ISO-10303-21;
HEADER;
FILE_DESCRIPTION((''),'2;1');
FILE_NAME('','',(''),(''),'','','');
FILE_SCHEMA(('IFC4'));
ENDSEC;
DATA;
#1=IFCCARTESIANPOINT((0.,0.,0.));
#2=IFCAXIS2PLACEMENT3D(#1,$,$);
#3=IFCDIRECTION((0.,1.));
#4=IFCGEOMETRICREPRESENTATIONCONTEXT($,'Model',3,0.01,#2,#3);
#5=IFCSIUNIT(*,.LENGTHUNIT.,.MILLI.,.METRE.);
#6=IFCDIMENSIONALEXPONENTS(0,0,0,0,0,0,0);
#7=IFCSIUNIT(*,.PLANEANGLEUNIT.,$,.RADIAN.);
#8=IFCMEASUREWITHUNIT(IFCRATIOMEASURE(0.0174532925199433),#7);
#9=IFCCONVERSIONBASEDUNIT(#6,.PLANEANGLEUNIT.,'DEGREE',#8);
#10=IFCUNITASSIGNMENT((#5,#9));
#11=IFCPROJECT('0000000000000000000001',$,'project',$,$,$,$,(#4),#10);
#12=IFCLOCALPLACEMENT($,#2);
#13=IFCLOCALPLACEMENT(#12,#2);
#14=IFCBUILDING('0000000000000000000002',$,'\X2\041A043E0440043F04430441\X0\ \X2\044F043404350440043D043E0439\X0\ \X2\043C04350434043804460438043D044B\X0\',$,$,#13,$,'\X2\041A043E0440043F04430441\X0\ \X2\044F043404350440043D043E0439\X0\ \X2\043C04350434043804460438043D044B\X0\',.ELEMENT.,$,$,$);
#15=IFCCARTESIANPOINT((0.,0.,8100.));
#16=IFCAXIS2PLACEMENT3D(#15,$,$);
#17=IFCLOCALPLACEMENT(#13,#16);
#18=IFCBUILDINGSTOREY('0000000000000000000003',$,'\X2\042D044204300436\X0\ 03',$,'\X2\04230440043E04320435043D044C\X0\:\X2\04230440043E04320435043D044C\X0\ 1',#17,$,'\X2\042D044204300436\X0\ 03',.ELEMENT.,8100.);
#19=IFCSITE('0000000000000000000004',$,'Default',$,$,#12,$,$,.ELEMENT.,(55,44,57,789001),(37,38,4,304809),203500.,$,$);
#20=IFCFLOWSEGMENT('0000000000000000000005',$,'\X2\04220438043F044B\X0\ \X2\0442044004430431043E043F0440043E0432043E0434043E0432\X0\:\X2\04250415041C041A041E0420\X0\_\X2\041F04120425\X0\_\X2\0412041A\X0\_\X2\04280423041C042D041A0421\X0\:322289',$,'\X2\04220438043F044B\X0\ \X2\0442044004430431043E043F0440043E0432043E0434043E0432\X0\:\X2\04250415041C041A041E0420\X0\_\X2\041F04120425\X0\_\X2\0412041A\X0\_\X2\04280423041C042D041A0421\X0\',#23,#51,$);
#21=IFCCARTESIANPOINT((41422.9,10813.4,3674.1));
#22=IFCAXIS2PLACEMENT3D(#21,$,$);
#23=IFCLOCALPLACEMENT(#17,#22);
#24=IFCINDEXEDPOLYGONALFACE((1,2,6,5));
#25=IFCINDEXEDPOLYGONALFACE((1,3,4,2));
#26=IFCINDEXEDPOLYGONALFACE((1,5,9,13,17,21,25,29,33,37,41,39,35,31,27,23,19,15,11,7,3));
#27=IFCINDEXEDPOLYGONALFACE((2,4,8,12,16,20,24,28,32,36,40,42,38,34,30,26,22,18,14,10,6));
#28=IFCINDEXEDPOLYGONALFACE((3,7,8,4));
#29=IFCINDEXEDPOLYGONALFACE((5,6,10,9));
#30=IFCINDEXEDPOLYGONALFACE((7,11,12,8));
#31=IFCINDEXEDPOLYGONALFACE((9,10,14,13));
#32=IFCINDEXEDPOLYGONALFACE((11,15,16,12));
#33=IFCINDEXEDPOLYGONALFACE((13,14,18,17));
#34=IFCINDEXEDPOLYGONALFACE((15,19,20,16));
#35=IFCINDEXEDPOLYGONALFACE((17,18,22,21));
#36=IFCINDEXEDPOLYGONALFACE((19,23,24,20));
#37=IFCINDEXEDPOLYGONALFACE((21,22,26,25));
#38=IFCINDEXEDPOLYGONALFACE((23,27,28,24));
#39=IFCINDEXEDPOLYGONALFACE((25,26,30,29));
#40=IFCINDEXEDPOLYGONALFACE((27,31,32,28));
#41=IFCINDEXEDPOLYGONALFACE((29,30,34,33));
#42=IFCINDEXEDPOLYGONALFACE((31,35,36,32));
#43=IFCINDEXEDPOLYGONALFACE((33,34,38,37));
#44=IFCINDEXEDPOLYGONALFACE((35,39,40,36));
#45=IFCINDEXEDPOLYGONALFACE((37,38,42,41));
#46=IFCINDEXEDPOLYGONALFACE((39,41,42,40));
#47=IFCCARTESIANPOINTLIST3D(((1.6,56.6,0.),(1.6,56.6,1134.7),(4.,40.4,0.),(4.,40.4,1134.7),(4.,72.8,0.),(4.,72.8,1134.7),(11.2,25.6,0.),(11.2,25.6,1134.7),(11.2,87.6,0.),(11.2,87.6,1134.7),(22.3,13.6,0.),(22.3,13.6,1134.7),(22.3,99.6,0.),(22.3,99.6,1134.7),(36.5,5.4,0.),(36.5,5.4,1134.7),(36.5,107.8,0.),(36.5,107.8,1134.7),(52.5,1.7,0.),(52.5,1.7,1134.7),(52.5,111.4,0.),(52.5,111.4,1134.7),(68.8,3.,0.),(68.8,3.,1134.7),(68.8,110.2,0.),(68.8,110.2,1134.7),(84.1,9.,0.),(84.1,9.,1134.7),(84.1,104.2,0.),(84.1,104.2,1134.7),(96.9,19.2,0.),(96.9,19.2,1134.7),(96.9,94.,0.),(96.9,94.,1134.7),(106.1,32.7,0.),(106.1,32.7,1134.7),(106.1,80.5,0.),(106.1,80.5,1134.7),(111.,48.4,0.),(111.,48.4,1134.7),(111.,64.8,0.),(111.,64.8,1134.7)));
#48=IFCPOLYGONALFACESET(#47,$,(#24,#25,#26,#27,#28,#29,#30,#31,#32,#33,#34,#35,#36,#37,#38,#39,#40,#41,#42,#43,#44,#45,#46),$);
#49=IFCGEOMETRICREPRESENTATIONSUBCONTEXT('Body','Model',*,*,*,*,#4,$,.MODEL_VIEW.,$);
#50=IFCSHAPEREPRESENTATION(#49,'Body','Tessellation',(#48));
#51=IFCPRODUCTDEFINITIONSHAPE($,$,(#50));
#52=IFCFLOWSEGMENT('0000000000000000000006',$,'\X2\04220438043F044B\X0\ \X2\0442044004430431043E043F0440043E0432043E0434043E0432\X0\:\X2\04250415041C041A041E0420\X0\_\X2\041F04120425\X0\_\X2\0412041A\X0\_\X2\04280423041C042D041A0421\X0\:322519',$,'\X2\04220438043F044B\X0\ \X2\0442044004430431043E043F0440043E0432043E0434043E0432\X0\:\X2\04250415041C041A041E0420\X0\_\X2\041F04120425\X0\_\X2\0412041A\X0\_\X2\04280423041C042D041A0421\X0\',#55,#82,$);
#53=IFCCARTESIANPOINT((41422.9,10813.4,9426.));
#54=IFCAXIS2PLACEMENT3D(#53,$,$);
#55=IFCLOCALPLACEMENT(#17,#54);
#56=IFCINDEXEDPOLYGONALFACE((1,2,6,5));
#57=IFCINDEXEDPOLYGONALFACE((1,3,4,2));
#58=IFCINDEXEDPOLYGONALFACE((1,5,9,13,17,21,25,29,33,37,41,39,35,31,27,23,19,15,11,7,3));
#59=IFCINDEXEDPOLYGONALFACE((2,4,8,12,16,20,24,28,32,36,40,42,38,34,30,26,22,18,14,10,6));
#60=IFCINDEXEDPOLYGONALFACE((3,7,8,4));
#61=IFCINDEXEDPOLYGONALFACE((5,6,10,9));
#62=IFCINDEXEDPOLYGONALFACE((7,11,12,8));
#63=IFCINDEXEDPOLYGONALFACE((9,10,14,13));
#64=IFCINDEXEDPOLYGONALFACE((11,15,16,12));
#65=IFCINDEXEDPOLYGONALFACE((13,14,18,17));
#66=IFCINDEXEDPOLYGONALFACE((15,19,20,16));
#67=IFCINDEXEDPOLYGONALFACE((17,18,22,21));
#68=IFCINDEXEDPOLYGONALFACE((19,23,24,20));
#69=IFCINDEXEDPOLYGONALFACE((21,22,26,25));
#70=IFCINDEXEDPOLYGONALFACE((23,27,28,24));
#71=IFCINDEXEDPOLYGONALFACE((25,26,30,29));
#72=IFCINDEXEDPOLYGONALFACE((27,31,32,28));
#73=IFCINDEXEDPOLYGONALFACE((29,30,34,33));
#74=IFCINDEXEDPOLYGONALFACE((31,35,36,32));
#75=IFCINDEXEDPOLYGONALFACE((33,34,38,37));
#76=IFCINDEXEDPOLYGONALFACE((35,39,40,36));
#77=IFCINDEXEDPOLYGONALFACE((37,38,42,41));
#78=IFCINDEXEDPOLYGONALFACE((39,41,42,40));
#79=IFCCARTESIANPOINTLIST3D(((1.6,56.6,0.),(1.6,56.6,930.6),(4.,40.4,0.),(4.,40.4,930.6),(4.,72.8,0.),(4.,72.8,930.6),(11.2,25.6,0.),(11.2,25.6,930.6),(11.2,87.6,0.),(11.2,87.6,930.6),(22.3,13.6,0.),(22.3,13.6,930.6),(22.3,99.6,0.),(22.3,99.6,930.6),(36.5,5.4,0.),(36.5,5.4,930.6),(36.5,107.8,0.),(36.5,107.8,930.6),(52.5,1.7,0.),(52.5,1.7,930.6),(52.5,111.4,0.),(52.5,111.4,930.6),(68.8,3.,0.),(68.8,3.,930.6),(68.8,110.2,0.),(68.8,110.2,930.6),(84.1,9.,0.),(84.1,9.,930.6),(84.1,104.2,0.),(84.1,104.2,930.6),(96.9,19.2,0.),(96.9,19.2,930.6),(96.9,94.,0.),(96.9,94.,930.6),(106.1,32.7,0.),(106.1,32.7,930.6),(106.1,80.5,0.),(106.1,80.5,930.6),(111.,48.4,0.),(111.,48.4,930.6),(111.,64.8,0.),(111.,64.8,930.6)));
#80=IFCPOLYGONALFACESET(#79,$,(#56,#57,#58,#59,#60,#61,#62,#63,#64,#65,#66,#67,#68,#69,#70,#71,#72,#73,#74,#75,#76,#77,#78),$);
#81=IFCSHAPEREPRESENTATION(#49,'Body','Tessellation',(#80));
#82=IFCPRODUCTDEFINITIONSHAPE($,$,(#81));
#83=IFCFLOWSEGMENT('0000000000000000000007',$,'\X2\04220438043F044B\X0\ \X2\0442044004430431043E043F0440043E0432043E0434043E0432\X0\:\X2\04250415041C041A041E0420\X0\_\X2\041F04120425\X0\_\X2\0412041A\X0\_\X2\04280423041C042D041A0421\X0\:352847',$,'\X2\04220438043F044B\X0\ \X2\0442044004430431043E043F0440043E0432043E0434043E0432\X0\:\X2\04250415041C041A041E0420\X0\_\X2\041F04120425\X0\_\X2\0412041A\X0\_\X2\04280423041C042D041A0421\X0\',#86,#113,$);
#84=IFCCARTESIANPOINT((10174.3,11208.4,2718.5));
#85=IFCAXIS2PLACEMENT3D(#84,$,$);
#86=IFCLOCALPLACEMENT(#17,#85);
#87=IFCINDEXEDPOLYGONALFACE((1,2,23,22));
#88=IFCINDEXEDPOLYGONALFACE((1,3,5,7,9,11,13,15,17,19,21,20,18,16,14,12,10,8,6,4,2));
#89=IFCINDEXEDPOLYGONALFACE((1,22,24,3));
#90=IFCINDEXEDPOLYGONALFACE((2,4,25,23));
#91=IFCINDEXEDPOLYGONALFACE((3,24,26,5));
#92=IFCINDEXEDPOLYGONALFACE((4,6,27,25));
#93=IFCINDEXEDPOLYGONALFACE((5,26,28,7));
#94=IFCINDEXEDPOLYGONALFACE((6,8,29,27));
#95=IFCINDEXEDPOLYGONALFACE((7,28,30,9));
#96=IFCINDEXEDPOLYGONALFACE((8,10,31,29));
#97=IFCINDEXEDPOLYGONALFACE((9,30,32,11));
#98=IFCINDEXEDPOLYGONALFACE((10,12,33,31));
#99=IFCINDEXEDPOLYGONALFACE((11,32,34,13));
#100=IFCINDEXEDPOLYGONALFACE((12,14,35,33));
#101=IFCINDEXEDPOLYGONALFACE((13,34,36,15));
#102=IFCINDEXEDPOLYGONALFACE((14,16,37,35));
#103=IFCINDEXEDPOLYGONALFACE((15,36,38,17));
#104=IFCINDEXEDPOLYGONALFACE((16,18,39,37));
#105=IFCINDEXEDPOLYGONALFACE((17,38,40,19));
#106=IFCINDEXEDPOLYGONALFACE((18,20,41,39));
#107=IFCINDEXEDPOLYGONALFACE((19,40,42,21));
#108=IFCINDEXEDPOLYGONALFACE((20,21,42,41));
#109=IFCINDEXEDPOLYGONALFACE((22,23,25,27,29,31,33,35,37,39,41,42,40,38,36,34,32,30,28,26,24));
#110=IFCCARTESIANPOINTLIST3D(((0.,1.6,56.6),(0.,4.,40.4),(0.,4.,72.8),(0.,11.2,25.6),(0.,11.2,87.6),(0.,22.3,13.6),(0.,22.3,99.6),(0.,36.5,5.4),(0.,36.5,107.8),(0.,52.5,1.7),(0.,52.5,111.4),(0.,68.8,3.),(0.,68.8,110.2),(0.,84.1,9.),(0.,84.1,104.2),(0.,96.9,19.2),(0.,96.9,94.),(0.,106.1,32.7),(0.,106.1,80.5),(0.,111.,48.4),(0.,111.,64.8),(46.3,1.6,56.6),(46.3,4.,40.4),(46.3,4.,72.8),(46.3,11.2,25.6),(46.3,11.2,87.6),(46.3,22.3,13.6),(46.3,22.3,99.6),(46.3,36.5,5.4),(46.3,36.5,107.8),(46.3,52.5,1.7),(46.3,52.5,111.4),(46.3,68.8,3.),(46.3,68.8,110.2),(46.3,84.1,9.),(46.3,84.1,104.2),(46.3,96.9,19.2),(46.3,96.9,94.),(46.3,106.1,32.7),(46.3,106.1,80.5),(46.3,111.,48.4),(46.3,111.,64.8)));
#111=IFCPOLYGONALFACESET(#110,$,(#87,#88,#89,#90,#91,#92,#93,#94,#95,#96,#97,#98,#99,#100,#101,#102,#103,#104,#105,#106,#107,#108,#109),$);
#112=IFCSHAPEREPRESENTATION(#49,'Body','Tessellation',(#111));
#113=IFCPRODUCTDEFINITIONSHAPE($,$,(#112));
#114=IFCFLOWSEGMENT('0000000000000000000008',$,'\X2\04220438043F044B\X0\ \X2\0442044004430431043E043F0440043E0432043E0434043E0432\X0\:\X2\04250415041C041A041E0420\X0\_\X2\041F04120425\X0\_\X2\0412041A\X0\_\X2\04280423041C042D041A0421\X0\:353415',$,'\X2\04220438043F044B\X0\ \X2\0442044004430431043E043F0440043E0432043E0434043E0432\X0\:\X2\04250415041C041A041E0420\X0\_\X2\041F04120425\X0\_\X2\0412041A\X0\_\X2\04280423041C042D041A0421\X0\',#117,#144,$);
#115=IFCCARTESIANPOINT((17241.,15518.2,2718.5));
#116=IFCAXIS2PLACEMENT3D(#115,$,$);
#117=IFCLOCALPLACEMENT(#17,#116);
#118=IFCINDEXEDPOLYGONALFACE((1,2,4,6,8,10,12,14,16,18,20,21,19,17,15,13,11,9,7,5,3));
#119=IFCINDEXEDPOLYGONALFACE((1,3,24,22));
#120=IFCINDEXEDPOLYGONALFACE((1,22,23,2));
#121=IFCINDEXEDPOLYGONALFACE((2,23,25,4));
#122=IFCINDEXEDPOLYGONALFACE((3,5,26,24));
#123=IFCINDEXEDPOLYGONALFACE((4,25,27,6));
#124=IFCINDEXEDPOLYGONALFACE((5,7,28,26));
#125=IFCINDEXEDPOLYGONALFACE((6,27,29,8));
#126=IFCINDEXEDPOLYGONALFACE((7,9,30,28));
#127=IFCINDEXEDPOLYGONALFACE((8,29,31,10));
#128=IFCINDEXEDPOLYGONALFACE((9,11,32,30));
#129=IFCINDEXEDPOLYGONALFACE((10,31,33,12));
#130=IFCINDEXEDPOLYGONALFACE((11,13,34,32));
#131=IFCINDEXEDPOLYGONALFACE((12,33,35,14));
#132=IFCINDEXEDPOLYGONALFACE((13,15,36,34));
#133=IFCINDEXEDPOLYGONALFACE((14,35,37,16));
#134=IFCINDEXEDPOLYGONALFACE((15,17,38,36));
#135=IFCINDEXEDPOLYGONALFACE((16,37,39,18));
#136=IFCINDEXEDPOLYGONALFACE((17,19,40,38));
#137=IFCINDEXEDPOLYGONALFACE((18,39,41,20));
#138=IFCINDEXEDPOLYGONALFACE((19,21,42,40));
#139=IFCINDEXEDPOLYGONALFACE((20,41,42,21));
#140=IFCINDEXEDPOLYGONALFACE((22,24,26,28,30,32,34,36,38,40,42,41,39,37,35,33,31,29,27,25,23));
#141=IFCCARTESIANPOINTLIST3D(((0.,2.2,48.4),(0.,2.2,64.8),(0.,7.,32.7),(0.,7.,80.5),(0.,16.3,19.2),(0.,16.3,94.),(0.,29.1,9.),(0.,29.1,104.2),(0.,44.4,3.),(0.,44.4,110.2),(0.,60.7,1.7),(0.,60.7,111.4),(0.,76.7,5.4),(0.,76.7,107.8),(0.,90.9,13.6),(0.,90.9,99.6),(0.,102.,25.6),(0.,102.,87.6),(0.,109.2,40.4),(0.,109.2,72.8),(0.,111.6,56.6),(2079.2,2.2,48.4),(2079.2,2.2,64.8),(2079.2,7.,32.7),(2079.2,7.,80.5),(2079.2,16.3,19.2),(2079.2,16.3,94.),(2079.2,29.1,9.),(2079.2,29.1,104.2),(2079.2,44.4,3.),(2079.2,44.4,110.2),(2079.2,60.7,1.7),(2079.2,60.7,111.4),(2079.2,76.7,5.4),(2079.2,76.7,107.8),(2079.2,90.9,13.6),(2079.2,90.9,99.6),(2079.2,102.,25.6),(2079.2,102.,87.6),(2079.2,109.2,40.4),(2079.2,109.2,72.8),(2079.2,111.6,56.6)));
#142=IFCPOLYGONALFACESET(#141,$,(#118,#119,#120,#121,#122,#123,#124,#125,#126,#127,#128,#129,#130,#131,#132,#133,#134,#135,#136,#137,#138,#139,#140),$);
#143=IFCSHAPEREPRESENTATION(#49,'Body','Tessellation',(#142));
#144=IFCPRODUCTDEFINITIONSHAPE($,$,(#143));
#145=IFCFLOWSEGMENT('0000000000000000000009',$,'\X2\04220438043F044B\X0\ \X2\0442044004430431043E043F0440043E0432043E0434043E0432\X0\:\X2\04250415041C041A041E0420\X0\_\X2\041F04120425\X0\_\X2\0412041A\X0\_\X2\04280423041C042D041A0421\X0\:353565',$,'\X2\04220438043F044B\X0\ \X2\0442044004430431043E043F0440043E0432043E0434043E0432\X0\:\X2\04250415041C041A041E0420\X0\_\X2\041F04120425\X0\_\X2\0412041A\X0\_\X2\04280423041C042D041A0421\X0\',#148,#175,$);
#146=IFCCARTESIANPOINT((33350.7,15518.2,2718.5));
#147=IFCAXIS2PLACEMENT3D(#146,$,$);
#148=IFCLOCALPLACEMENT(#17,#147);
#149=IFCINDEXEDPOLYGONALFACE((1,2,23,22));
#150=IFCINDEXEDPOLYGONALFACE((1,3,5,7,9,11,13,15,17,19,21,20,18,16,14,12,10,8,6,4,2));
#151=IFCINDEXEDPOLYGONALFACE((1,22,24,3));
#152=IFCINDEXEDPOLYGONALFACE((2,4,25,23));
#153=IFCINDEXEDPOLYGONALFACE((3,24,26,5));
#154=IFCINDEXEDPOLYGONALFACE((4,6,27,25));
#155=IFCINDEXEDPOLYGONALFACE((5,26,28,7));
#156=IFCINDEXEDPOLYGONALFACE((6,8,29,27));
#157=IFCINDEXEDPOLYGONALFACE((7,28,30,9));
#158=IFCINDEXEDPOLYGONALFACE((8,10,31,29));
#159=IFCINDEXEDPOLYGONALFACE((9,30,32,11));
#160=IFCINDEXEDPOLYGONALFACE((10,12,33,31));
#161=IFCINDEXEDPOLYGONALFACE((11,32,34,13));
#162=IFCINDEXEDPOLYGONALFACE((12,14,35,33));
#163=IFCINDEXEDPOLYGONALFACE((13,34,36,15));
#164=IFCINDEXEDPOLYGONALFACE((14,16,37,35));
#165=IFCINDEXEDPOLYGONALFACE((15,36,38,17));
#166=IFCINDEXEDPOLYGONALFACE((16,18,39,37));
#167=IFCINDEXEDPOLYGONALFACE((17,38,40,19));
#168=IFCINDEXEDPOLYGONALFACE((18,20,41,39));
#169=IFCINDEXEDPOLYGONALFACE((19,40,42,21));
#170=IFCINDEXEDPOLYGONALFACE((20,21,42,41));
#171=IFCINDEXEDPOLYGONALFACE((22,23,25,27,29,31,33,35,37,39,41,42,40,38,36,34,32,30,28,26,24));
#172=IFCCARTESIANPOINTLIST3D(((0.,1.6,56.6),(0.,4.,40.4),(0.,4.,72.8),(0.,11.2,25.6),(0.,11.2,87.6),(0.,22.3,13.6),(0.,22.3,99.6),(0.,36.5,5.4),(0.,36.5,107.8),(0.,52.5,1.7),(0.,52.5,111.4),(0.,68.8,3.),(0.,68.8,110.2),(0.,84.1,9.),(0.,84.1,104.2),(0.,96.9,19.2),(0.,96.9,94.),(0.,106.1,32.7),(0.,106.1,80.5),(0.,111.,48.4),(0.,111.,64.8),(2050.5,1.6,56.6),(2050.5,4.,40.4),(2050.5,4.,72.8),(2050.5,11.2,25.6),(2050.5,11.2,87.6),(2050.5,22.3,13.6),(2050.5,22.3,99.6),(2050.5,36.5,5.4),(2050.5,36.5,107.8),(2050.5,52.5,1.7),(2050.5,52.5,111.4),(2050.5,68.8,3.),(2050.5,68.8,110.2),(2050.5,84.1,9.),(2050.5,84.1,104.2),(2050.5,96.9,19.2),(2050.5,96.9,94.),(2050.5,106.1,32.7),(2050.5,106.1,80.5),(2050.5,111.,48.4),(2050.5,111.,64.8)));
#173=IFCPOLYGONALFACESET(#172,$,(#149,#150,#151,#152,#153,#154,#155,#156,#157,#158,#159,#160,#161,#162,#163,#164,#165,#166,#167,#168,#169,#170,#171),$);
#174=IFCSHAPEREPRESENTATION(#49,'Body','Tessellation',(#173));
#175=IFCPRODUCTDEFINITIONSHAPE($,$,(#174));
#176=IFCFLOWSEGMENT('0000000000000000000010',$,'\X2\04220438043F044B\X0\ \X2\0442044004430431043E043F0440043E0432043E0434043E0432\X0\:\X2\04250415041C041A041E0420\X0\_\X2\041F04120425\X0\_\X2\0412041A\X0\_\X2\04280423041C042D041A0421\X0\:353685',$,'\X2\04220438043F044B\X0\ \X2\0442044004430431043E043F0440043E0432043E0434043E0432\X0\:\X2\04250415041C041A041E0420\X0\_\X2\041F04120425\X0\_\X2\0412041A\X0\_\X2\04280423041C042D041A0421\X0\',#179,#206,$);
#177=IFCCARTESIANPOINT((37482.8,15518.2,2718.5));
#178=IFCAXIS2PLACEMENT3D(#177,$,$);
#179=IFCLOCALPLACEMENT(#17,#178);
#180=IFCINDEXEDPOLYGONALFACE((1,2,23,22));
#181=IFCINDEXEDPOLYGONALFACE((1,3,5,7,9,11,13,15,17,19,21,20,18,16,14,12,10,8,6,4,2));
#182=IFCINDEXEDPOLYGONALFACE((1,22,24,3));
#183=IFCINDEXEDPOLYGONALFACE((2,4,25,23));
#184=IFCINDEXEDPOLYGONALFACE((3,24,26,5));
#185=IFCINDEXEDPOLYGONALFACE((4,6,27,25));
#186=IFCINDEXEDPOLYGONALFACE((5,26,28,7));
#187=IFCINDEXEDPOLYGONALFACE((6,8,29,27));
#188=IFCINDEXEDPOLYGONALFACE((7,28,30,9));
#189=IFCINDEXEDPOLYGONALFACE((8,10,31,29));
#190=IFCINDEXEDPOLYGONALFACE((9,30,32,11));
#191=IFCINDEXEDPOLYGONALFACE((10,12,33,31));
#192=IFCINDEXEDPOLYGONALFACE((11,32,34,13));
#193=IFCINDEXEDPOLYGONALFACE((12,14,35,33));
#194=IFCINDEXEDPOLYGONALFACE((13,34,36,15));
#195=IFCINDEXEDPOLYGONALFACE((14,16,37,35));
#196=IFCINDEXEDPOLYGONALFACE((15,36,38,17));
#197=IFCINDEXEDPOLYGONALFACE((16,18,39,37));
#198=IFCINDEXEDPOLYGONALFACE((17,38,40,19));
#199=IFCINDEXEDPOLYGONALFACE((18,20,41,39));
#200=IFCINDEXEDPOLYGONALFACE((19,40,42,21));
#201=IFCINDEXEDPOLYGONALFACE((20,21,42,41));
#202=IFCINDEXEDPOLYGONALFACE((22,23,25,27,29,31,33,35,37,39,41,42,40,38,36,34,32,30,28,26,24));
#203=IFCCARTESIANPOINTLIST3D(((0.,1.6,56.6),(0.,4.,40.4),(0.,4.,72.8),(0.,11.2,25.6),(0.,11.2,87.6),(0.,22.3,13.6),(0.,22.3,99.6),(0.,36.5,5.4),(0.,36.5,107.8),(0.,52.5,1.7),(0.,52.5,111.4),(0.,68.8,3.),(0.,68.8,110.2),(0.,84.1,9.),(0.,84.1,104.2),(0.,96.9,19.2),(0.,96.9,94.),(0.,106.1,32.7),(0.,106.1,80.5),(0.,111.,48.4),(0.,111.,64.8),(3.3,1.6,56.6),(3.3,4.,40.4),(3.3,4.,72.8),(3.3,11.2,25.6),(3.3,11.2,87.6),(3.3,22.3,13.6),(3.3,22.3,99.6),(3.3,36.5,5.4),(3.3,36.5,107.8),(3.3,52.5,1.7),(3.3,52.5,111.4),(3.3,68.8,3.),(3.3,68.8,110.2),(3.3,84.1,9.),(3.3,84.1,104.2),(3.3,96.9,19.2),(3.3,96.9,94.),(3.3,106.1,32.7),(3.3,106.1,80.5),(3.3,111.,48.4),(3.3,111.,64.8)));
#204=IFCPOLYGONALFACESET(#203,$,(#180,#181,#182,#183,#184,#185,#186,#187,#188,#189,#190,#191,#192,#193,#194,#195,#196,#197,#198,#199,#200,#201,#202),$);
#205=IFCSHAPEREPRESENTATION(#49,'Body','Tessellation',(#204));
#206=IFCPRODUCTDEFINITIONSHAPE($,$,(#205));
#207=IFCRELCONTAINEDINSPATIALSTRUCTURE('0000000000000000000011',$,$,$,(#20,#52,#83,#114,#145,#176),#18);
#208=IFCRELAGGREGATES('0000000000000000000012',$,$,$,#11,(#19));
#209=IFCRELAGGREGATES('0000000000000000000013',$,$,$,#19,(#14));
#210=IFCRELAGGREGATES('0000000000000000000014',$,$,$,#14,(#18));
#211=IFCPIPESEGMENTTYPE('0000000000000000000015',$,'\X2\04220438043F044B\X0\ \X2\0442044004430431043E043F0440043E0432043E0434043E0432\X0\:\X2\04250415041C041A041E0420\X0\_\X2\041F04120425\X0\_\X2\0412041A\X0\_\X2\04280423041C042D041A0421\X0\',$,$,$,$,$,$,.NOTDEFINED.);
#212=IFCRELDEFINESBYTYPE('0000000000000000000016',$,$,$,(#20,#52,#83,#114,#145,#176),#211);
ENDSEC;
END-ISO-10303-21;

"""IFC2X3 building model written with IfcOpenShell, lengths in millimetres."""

from ifc_helpers import new_model, entity, si_unit, converted_unit, direction, frame, origin, origin_2d_with_axis, place, context, subcontext, project, spatial, circle, extrude, type_object, element, save


model = new_model("IFC2X3")

# Units and contexts
model_context = context("Model", 3, precision=0.01, world=origin(), true_north=direction((0.0, 1.0)))
body_context = subcontext(model_context, "Body", "Model", "MODEL_VIEW")
ifc_project = project(units=[si_unit("LENGTHUNIT", "METRE", prefix="MILLI"), converted_unit("PLANEANGLEUNIT", "DEGREE", entity("IfcRatioMeasure", 0.0174532925199433), si_unit("PLANEANGLEUNIT", "RADIAN"), dimensions=[0, 0, 0, 0, 0, 0, 0])], contexts=[model_context])

# Site, building, storey
site_placement = place(None, frame((0.0, 0.0, 0.0)))
site = spatial("IfcSite", under=ifc_project, at=site_placement, Name="Default", CompositionType="ELEMENT", RefLatitude=(55, 44, 57, 789001), RefLongitude=(37, 38, 4, 304809), RefElevation=203500.0)
building_placement = place(site_placement, origin())
building = spatial("IfcBuilding", under=site, at=building_placement, Name="Корпус ядерной медицины", LongName="Корпус ядерной медицины", CompositionType="ELEMENT")
storey_placement = place(building_placement, frame((0.0, 0.0, 8100.0)))
storey = spatial("IfcBuildingStorey", under=building, at=storey_placement, Name="Этаж 03", ObjectType="Уровень:Уровень 1", LongName="Этаж 03", CompositionType="ELEMENT", Elevation=8100.0)

# Flow segments
pipe_segment_type = type_object("IfcPipeSegmentType", Name="Типы трубопроводов:ХЕМКОР_ПВХ_ВК_ШУМЭКС", PredefinedType="NOTDEFINED")
flow_segment_1_placement = place(storey_placement, frame((41422.9, 10813.4, 3674.1)))
element("IfcFlowSegment", 1, at=flow_segment_1_placement, inside=storey, type_object=pipe_segment_type, Name="Типы трубопроводов:ХЕМКОР_ПВХ_ВК_ШУМЭКС:322289", ObjectType="Типы трубопроводов:ХЕМКОР_ПВХ_ВК_ШУМЭКС", context=body_context, shape_type="SweptSolid", body=[
    extrude(circle(Radius=55.0, at=origin_2d_with_axis()), frame((56.6, 56.6, 0.0), z_axis=(0.0, 0.0, 1.0), x_axis=(-1.0, 0.0, 0.0)), (0.0, 0.0, 1.0), 1134.7),
])
flow_segment_2_placement = place(storey_placement, frame((41422.9, 10813.4, 9426.0)))
element("IfcFlowSegment", 2, at=flow_segment_2_placement, inside=storey, type_object=pipe_segment_type, Name="Типы трубопроводов:ХЕМКОР_ПВХ_ВК_ШУМЭКС:322519", ObjectType="Типы трубопроводов:ХЕМКОР_ПВХ_ВК_ШУМЭКС", context=body_context, shape_type="SweptSolid", body=[
    extrude(circle(Radius=55.0, at=origin_2d_with_axis()), frame((56.6, 56.6, 0.0), z_axis=(0.0, 0.0, 1.0), x_axis=(-1.0, 0.0, 0.0)), (0.0, 0.0, 1.0), 930.6),
])
flow_segment_3_placement = place(storey_placement, frame((10174.3, 11208.4, 2718.5)))
element("IfcFlowSegment", 3, at=flow_segment_3_placement, inside=storey, type_object=pipe_segment_type, Name="Типы трубопроводов:ХЕМКОР_ПВХ_ВК_ШУМЭКС:352847", ObjectType="Типы трубопроводов:ХЕМКОР_ПВХ_ВК_ШУМЭКС", context=body_context, shape_type="SweptSolid", body=[
    extrude(circle(Radius=55.0, at=origin_2d_with_axis()), frame((0.0, 56.6, 56.6), z_axis=(1.0, 0.0, 0.0), x_axis=(0.0, -1.0, 0.0)), (0.0, 0.0, 1.0), 46.3),
])
flow_segment_4_placement = place(storey_placement, frame((17241.0, 15518.2, 2718.5)))
element("IfcFlowSegment", 4, at=flow_segment_4_placement, inside=storey, type_object=pipe_segment_type, Name="Типы трубопроводов:ХЕМКОР_ПВХ_ВК_ШУМЭКС:353415", ObjectType="Типы трубопроводов:ХЕМКОР_ПВХ_ВК_ШУМЭКС", context=body_context, shape_type="SweptSolid", body=[
    extrude(circle(Radius=55.0, at=origin_2d_with_axis()), frame((0.0, 56.6, 56.6), z_axis=(1.0, 0.0, 0.0), x_axis=(0.0, 1.0, 0.0)), (0.0, 0.0, 1.0), 2079.2),
])
flow_segment_5_placement = place(storey_placement, frame((33350.7, 15518.2, 2718.5)))
element("IfcFlowSegment", 5, at=flow_segment_5_placement, inside=storey, type_object=pipe_segment_type, Name="Типы трубопроводов:ХЕМКОР_ПВХ_ВК_ШУМЭКС:353565", ObjectType="Типы трубопроводов:ХЕМКОР_ПВХ_ВК_ШУМЭКС", context=body_context, shape_type="SweptSolid", body=[
    extrude(circle(Radius=55.0, at=origin_2d_with_axis()), frame((0.0, 56.6, 56.6), z_axis=(1.0, 0.0, 0.0), x_axis=(0.0, -1.0, 0.0)), (0.0, 0.0, 1.0), 2050.5),
])
flow_segment_6_placement = place(storey_placement, frame((37482.8, 15518.2, 2718.5)))
element("IfcFlowSegment", 6, at=flow_segment_6_placement, inside=storey, type_object=pipe_segment_type, Name="Типы трубопроводов:ХЕМКОР_ПВХ_ВК_ШУМЭКС:353685", ObjectType="Типы трубопроводов:ХЕМКОР_ПВХ_ВК_ШУМЭКС", context=body_context, shape_type="SweptSolid", body=[
    extrude(circle(Radius=55.0, at=origin_2d_with_axis()), frame((0.0, 56.6, 56.6), z_axis=(1.0, 0.0, 0.0), x_axis=(0.0, -1.0, 0.0)), (0.0, 0.0, 1.0), 3.3),
])

save(model, "model.ifc")
